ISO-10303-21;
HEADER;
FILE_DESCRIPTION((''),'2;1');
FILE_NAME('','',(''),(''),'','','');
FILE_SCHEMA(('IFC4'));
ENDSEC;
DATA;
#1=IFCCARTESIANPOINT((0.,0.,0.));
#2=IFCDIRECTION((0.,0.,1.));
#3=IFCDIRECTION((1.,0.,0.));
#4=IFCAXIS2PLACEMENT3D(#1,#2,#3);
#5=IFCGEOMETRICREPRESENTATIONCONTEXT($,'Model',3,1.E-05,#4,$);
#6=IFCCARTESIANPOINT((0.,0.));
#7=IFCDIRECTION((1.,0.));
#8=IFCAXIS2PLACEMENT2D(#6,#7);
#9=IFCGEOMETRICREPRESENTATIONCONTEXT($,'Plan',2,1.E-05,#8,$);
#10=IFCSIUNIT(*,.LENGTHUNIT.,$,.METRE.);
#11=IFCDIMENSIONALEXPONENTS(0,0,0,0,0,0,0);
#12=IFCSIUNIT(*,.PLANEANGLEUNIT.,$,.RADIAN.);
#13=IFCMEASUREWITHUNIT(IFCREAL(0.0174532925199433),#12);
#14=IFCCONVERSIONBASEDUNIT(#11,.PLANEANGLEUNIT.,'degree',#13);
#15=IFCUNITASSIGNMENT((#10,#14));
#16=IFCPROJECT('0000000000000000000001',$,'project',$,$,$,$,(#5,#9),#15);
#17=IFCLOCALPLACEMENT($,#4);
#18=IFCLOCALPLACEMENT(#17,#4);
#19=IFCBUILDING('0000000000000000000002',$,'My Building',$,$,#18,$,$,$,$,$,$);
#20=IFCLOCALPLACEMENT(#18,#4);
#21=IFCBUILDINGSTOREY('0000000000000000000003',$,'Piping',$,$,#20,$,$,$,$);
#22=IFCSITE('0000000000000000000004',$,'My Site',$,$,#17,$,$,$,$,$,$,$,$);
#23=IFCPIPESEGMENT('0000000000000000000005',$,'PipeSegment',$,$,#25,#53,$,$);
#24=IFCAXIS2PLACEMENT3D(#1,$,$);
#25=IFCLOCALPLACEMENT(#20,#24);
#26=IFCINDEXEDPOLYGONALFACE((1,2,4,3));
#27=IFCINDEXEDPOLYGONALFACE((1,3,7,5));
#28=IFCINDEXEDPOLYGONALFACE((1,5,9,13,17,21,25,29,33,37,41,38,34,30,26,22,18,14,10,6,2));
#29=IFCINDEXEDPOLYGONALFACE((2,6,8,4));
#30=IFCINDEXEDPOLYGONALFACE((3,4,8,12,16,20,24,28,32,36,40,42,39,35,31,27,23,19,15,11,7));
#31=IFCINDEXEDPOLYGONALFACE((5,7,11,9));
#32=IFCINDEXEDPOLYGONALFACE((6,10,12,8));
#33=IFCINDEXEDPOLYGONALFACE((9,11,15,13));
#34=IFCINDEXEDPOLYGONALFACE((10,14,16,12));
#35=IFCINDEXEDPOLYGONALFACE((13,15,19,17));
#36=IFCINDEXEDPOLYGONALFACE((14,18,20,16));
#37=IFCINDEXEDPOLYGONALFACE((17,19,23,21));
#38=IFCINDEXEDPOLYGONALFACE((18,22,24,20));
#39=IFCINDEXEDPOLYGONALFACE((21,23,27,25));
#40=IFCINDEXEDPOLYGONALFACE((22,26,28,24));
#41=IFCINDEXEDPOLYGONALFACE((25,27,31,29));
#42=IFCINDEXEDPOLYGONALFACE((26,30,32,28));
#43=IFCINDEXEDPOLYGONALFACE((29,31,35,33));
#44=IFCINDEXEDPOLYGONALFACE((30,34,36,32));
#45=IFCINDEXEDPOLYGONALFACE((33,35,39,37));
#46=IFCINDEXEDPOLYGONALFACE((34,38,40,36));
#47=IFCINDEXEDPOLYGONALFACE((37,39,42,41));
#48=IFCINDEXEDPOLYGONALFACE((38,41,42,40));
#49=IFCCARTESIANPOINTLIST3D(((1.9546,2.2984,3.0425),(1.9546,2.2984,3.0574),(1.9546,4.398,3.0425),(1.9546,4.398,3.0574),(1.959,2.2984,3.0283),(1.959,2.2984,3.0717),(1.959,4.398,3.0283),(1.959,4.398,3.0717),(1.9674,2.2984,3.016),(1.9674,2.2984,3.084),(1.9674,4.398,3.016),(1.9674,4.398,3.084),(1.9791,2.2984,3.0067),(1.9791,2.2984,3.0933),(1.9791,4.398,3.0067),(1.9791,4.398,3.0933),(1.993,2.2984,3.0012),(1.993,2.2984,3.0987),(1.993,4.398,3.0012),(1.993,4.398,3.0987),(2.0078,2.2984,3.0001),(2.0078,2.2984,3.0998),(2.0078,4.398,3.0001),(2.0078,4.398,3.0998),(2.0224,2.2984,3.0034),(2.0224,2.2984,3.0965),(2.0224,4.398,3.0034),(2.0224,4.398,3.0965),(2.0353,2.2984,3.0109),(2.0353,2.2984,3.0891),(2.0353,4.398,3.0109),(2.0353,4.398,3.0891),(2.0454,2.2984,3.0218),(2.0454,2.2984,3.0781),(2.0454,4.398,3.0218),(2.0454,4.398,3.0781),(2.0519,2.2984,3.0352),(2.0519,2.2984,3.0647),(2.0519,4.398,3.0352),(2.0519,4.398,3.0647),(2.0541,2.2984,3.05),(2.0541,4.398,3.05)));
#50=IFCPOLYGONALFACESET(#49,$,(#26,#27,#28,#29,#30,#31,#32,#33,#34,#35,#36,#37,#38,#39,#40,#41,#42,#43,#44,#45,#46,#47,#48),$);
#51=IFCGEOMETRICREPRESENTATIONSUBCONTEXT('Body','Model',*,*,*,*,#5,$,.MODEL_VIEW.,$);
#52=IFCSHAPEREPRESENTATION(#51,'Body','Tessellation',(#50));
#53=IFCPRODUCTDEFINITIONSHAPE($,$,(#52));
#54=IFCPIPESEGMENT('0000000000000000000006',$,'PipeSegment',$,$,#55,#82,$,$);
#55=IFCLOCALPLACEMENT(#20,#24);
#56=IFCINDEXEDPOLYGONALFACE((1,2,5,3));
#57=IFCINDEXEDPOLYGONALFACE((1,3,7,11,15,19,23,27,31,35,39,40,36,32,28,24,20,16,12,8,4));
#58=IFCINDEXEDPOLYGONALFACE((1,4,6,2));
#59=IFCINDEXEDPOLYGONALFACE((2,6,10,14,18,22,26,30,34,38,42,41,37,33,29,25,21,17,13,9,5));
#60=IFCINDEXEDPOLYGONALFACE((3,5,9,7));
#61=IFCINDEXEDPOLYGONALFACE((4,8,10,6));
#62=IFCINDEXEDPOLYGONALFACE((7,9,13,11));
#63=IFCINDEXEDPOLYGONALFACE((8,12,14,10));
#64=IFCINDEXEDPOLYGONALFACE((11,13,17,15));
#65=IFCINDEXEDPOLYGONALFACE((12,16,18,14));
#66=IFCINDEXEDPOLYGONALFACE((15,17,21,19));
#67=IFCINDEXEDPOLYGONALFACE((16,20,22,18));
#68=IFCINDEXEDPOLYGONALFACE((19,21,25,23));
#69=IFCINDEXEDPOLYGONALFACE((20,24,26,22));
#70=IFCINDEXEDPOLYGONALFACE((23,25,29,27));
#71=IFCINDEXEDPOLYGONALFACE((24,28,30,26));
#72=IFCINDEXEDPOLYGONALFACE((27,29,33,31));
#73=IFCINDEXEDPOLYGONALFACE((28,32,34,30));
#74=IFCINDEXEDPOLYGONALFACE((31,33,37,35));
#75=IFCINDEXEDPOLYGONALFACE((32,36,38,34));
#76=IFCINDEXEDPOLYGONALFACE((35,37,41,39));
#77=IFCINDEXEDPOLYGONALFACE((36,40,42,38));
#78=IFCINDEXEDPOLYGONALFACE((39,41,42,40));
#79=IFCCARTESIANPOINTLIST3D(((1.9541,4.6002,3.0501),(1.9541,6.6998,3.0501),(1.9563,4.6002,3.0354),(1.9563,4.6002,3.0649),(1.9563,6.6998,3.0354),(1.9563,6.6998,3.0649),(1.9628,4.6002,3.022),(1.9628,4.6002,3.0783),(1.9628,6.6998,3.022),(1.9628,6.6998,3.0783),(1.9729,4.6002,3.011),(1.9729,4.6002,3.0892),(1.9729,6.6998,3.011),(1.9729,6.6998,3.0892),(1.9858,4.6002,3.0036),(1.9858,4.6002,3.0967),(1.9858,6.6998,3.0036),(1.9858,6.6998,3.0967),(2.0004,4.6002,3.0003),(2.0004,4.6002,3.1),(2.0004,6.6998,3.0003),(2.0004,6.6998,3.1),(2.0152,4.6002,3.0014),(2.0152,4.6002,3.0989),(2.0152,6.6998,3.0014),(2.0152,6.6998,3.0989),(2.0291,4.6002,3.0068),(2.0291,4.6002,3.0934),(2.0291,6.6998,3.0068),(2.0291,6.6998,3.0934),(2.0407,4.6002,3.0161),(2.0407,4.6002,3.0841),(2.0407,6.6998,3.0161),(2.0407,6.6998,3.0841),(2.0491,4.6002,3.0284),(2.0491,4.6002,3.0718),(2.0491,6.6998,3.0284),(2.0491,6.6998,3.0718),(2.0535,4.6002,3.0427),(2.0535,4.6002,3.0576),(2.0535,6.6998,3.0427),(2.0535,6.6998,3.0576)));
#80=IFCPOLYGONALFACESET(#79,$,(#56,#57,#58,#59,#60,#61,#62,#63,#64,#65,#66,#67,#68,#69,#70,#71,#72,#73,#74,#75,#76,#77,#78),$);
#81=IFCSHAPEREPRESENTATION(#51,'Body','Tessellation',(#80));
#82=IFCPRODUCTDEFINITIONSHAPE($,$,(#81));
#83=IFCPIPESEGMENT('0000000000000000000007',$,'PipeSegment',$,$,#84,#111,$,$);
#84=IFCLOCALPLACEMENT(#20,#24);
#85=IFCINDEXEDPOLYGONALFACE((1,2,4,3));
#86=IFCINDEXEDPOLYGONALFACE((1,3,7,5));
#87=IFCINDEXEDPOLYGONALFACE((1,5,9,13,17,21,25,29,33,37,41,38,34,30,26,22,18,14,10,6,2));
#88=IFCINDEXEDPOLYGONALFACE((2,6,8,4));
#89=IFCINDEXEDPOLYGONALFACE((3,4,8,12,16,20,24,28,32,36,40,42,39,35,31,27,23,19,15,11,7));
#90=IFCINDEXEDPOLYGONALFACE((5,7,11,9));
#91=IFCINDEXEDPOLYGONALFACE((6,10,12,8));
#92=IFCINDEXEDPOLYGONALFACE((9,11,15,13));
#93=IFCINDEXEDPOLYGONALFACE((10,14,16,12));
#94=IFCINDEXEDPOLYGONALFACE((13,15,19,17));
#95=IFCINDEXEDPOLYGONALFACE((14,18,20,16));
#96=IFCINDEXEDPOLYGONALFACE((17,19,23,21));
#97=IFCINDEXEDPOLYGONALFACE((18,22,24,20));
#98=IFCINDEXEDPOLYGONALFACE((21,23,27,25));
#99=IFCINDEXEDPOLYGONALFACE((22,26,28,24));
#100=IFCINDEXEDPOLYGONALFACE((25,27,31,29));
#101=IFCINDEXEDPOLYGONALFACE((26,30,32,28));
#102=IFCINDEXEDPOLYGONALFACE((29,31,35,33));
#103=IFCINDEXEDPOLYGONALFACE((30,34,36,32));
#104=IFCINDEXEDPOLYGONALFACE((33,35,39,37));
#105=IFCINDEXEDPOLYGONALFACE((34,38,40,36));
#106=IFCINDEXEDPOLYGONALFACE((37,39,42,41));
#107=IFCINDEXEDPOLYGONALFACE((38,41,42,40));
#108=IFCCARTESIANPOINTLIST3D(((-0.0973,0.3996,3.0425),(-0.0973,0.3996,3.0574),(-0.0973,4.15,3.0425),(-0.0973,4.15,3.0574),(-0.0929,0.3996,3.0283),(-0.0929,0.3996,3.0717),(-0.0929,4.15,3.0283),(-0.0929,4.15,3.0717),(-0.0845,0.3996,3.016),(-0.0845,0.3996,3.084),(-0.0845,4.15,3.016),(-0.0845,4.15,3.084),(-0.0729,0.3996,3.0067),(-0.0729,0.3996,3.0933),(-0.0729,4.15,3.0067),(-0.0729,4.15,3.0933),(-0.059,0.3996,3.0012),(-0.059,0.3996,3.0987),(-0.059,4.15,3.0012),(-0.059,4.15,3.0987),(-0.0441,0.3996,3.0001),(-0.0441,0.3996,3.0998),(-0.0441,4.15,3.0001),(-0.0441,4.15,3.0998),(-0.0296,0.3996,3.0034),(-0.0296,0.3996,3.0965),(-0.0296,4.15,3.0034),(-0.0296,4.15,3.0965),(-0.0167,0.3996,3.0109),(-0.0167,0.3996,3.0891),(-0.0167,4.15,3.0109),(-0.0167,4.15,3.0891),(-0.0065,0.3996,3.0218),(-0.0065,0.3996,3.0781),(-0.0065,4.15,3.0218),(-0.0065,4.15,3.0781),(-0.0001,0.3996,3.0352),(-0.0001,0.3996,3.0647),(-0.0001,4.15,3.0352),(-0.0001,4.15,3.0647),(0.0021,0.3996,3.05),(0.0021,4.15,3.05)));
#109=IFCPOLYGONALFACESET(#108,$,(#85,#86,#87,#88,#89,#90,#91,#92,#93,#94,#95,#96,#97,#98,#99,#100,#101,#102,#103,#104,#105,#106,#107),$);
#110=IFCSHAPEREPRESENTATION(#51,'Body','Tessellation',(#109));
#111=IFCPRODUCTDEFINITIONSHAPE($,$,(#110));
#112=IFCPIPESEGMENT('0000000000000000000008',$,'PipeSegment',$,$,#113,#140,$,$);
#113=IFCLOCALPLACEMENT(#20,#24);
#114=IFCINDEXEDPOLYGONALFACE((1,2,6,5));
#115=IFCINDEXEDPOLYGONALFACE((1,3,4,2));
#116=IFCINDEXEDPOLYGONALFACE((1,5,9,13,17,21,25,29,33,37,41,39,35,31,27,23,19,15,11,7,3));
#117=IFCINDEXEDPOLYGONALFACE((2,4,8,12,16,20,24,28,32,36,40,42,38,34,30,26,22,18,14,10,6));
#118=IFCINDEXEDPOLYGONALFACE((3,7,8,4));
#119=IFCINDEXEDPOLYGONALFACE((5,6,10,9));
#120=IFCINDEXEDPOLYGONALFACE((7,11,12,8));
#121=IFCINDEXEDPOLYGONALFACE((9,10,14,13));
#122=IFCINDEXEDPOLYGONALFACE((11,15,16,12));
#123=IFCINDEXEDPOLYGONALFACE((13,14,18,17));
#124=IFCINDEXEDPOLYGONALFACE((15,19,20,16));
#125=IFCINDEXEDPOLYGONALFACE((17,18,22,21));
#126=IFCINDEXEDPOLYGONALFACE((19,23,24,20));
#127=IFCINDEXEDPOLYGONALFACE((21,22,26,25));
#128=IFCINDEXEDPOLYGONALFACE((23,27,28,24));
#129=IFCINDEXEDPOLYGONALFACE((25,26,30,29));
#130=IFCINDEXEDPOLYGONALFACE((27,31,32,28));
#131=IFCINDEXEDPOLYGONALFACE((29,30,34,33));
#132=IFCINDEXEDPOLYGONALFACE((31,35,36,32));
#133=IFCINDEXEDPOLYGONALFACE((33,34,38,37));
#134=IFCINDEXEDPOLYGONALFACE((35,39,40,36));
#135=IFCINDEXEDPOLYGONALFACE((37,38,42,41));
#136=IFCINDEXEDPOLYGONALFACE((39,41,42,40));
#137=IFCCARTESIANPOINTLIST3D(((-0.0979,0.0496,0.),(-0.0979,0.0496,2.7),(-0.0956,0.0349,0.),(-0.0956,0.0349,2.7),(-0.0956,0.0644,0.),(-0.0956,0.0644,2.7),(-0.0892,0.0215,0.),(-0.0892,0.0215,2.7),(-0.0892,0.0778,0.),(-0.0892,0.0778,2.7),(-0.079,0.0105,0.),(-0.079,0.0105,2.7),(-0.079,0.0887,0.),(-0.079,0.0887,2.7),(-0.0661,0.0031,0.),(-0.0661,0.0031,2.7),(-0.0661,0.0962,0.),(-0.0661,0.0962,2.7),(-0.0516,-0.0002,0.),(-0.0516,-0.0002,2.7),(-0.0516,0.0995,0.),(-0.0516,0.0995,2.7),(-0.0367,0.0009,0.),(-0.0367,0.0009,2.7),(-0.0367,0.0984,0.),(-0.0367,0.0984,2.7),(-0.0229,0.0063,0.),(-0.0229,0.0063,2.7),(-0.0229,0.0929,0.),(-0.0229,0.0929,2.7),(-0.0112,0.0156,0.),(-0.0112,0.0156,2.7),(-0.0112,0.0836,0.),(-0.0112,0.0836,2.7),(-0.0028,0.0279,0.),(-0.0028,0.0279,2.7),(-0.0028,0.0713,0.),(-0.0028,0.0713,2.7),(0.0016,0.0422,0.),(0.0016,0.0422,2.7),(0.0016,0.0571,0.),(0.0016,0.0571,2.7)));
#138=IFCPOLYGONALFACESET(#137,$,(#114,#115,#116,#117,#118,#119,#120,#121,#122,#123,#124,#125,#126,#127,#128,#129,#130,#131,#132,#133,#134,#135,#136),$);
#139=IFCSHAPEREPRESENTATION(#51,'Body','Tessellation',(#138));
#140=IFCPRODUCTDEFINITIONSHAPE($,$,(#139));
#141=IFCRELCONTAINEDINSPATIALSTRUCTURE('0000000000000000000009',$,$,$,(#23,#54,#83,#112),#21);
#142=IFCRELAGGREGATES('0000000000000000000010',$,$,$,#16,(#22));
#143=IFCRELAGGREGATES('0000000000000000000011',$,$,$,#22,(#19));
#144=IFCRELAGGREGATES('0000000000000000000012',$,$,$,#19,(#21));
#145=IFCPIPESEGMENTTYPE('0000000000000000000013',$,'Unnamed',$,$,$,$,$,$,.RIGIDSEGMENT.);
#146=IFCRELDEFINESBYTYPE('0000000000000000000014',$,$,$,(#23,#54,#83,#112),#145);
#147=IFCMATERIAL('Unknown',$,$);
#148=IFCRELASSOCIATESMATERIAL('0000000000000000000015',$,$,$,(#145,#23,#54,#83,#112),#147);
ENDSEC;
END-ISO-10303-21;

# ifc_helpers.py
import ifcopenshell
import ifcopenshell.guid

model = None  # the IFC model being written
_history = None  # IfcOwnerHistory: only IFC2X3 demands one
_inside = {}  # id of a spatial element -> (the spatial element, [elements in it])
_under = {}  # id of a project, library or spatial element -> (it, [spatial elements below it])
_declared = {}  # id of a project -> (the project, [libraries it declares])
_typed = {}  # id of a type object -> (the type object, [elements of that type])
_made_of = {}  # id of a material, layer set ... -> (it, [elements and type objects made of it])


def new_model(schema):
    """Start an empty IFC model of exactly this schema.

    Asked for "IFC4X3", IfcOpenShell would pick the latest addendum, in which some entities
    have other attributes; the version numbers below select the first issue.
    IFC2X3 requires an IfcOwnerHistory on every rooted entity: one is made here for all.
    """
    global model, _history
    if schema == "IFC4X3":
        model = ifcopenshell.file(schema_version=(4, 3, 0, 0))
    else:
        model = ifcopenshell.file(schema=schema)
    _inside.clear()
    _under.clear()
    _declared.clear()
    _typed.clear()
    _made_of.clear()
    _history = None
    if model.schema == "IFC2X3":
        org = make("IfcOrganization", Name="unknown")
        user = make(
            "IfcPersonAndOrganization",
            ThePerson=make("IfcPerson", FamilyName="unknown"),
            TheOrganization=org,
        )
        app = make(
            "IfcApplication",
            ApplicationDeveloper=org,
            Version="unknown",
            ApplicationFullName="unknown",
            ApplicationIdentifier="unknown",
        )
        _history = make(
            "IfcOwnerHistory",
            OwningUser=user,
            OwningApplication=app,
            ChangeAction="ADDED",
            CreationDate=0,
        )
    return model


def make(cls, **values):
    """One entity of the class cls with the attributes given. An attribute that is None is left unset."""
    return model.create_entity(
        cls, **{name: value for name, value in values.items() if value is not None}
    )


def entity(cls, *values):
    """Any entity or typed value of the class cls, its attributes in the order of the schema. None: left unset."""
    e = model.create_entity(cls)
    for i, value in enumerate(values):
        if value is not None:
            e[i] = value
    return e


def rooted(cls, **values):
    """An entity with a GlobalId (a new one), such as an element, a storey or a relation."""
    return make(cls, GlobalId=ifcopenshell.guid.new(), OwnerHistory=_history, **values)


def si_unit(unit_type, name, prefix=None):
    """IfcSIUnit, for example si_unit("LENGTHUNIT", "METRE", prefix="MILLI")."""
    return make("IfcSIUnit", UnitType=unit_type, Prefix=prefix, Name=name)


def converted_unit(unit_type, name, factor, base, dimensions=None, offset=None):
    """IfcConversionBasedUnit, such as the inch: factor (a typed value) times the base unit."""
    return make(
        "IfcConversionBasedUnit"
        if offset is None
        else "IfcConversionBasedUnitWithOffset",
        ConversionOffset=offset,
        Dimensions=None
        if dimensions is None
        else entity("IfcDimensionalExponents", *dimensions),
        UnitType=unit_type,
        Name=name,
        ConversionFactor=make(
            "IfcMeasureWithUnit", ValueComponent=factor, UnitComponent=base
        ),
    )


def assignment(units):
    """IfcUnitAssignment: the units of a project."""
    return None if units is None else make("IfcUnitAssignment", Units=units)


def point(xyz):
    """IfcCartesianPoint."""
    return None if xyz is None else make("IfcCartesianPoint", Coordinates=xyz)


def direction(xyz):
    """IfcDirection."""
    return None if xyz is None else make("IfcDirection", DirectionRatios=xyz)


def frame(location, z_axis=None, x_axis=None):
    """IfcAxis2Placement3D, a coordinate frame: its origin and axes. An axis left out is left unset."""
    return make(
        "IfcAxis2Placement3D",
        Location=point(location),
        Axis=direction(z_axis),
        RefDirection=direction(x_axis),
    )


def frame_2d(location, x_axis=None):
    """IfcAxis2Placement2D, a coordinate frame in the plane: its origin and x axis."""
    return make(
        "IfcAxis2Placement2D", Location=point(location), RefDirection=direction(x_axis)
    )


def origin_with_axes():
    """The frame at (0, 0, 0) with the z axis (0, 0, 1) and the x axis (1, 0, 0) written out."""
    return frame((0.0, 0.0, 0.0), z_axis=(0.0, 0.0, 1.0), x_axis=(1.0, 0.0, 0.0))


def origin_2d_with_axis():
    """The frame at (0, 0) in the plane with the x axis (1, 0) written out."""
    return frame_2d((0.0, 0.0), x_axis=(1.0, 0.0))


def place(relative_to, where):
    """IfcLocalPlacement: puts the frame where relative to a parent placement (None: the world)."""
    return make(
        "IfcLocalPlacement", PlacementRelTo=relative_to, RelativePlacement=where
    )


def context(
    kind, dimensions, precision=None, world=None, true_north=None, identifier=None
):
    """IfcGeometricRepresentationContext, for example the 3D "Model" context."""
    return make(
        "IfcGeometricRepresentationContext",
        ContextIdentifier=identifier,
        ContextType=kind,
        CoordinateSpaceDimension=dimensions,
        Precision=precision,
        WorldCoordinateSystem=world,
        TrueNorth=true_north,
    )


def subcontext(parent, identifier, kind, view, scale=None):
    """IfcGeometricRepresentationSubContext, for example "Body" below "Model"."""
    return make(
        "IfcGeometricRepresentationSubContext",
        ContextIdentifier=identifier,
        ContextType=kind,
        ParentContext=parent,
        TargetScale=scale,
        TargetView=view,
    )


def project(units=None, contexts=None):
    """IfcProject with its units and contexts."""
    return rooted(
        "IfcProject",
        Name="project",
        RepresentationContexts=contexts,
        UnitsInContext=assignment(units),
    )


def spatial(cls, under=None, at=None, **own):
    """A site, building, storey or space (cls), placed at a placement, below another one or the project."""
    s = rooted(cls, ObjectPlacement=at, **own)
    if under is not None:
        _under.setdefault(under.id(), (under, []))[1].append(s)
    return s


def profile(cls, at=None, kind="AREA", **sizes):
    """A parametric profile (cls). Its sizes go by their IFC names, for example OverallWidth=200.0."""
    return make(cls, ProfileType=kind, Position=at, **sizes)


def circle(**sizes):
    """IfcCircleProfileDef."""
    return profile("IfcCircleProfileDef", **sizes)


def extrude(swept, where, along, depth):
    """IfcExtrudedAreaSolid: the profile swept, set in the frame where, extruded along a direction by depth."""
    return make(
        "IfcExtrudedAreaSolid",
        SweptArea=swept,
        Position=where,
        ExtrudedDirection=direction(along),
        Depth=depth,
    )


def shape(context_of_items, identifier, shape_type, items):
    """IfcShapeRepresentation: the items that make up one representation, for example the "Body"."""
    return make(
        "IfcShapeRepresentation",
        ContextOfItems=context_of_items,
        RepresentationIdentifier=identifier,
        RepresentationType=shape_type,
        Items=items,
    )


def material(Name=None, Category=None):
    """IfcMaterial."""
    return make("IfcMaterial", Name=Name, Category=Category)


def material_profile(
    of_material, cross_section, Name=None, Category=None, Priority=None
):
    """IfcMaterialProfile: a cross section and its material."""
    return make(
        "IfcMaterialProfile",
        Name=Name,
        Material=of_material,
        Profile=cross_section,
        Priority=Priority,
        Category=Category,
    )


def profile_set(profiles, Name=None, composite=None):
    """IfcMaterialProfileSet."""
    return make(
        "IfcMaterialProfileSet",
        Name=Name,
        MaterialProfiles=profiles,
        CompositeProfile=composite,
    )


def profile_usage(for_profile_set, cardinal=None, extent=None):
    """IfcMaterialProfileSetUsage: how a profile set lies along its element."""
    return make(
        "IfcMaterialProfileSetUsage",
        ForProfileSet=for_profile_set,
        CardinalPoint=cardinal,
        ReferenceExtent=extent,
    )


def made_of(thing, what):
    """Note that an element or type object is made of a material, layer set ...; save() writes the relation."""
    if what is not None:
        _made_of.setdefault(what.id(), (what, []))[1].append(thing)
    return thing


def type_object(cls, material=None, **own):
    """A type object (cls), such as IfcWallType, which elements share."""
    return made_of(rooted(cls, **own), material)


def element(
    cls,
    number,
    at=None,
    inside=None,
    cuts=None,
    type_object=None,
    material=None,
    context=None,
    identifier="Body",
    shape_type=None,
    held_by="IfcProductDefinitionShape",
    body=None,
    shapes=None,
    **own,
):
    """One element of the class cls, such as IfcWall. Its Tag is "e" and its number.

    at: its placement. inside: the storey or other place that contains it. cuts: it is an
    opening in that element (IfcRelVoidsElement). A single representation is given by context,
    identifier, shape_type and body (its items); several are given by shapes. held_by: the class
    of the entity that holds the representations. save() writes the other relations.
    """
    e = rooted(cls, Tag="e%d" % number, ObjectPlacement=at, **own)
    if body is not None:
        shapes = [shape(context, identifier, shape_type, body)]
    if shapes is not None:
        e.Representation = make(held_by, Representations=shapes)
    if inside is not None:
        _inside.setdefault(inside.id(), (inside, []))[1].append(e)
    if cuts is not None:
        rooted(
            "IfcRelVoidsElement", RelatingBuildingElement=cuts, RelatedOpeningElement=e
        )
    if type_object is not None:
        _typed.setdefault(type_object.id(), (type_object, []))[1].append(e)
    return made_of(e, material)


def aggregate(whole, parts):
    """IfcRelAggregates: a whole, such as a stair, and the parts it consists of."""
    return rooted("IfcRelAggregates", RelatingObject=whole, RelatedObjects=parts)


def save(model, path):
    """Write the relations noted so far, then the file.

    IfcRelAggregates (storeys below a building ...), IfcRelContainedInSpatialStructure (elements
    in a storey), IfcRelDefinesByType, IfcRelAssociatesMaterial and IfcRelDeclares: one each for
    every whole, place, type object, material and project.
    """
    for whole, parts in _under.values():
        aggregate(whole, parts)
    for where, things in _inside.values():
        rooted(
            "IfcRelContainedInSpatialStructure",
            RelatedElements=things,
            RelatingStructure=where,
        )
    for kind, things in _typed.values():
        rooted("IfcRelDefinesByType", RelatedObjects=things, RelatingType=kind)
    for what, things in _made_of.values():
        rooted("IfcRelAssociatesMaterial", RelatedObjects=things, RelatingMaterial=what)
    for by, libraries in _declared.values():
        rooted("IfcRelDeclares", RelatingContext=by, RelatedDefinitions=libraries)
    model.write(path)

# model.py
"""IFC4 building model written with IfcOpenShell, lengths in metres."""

from ifc_helpers import new_model, entity, si_unit, converted_unit, frame, origin_with_axes, origin_2d_with_axis, place, context, subcontext, project, spatial, circle, extrude, material, material_profile, profile_set, profile_usage, type_object, element, save


model = new_model("IFC4")

# Units and contexts
model_context = context("Model", 3, precision=1e-05, world=origin_with_axes())
plan_context = context("Plan", 2, precision=1e-05, world=origin_2d_with_axis())
body_context = subcontext(model_context, "Body", "Model", "MODEL_VIEW")
ifc_project = project(units=[si_unit("LENGTHUNIT", "METRE"), converted_unit("PLANEANGLEUNIT", "degree", entity("IfcReal", 0.0174532925199433), si_unit("PLANEANGLEUNIT", "RADIAN"), dimensions=[0, 0, 0, 0, 0, 0, 0])], contexts=[model_context, plan_context])

# Site, building, storey
site_placement = place(None, origin_with_axes())
site = spatial("IfcSite", under=ifc_project, at=site_placement, Name="My Site")
building_placement = place(site_placement, origin_with_axes())
building = spatial("IfcBuilding", under=site, at=building_placement, Name="My Building")
storey_placement = place(building_placement, origin_with_axes())
storey = spatial("IfcBuildingStorey", under=building, at=storey_placement, Name="Piping")

# Pipe segments
ifc_material = material(Name="Unknown")
ifc_material_profile_1 = material_profile(ifc_material, circle(Radius=0.05))
ifc_profile_set_1 = profile_set([ifc_material_profile_1])
pipe_segment_type = type_object("IfcPipeSegmentType", Name="Unnamed", PredefinedType="RIGIDSEGMENT", material=ifc_profile_set_1)
ifc_profile_usage_1 = profile_usage(ifc_profile_set_1, cardinal=5)
pipe_segment_1_placement = place(storey_placement, frame((2.0041, 2.2984, 3.05), z_axis=(0.0, 1.0, -0.000001), x_axis=(1.0, 0.0, 0.000001)))
element("IfcPipeSegment", 1, at=pipe_segment_1_placement, inside=storey, type_object=pipe_segment_type, material=ifc_profile_usage_1, Name="PipeSegment", context=body_context, shape_type="SweptSolid", body=[
    extrude(circle(Radius=0.05), origin_with_axes(), (0.0, 0.0, 1.0), 2.0996),
])
ifc_profile_usage_2 = profile_usage(ifc_profile_set_1, cardinal=5)
pipe_segment_2_placement = place(storey_placement, frame((2.0041, 6.6998, 3.0501), z_axis=(0.0, -1.0, -0.000001), x_axis=(-1.0, 0.0, 0.000001)))
element("IfcPipeSegment", 2, at=pipe_segment_2_placement, inside=storey, type_object=pipe_segment_type, material=ifc_profile_usage_2, Name="PipeSegment", context=body_context, shape_type="SweptSolid", body=[
    extrude(circle(Radius=0.05), origin_with_axes(), (0.0, 0.0, 1.0), 2.0996),
])
ifc_profile_usage_3 = profile_usage(ifc_profile_set_1, cardinal=5)
pipe_segment_3_placement = place(storey_placement, frame((-0.0479, 4.15, 3.05), z_axis=(0.0, -1.0, 0.0), x_axis=(1.0, 0.0, 0.0)))
element("IfcPipeSegment", 3, at=pipe_segment_3_placement, inside=storey, type_object=pipe_segment_type, material=ifc_profile_usage_3, Name="PipeSegment", context=body_context, shape_type="SweptSolid", body=[
    extrude(circle(Radius=0.05), origin_with_axes(), (0.0, 0.0, 1.0), 3.7504),
])
ifc_profile_usage_4 = profile_usage(ifc_profile_set_1, cardinal=5)
pipe_segment_4_placement = place(storey_placement, frame((-0.0479, 0.0496, 2.7), z_axis=(0.0, 0.0, -1.0), x_axis=(-1.0, 0.0, 0.0)))
element("IfcPipeSegment", 4, at=pipe_segment_4_placement, inside=storey, type_object=pipe_segment_type, material=ifc_profile_usage_4, Name="PipeSegment", context=body_context, shape_type="SweptSolid", body=[
    extrude(circle(Radius=0.05), origin_with_axes(), (0.0, 0.0, 1.0), 2.7),
])

save(model, "model.ifc")
